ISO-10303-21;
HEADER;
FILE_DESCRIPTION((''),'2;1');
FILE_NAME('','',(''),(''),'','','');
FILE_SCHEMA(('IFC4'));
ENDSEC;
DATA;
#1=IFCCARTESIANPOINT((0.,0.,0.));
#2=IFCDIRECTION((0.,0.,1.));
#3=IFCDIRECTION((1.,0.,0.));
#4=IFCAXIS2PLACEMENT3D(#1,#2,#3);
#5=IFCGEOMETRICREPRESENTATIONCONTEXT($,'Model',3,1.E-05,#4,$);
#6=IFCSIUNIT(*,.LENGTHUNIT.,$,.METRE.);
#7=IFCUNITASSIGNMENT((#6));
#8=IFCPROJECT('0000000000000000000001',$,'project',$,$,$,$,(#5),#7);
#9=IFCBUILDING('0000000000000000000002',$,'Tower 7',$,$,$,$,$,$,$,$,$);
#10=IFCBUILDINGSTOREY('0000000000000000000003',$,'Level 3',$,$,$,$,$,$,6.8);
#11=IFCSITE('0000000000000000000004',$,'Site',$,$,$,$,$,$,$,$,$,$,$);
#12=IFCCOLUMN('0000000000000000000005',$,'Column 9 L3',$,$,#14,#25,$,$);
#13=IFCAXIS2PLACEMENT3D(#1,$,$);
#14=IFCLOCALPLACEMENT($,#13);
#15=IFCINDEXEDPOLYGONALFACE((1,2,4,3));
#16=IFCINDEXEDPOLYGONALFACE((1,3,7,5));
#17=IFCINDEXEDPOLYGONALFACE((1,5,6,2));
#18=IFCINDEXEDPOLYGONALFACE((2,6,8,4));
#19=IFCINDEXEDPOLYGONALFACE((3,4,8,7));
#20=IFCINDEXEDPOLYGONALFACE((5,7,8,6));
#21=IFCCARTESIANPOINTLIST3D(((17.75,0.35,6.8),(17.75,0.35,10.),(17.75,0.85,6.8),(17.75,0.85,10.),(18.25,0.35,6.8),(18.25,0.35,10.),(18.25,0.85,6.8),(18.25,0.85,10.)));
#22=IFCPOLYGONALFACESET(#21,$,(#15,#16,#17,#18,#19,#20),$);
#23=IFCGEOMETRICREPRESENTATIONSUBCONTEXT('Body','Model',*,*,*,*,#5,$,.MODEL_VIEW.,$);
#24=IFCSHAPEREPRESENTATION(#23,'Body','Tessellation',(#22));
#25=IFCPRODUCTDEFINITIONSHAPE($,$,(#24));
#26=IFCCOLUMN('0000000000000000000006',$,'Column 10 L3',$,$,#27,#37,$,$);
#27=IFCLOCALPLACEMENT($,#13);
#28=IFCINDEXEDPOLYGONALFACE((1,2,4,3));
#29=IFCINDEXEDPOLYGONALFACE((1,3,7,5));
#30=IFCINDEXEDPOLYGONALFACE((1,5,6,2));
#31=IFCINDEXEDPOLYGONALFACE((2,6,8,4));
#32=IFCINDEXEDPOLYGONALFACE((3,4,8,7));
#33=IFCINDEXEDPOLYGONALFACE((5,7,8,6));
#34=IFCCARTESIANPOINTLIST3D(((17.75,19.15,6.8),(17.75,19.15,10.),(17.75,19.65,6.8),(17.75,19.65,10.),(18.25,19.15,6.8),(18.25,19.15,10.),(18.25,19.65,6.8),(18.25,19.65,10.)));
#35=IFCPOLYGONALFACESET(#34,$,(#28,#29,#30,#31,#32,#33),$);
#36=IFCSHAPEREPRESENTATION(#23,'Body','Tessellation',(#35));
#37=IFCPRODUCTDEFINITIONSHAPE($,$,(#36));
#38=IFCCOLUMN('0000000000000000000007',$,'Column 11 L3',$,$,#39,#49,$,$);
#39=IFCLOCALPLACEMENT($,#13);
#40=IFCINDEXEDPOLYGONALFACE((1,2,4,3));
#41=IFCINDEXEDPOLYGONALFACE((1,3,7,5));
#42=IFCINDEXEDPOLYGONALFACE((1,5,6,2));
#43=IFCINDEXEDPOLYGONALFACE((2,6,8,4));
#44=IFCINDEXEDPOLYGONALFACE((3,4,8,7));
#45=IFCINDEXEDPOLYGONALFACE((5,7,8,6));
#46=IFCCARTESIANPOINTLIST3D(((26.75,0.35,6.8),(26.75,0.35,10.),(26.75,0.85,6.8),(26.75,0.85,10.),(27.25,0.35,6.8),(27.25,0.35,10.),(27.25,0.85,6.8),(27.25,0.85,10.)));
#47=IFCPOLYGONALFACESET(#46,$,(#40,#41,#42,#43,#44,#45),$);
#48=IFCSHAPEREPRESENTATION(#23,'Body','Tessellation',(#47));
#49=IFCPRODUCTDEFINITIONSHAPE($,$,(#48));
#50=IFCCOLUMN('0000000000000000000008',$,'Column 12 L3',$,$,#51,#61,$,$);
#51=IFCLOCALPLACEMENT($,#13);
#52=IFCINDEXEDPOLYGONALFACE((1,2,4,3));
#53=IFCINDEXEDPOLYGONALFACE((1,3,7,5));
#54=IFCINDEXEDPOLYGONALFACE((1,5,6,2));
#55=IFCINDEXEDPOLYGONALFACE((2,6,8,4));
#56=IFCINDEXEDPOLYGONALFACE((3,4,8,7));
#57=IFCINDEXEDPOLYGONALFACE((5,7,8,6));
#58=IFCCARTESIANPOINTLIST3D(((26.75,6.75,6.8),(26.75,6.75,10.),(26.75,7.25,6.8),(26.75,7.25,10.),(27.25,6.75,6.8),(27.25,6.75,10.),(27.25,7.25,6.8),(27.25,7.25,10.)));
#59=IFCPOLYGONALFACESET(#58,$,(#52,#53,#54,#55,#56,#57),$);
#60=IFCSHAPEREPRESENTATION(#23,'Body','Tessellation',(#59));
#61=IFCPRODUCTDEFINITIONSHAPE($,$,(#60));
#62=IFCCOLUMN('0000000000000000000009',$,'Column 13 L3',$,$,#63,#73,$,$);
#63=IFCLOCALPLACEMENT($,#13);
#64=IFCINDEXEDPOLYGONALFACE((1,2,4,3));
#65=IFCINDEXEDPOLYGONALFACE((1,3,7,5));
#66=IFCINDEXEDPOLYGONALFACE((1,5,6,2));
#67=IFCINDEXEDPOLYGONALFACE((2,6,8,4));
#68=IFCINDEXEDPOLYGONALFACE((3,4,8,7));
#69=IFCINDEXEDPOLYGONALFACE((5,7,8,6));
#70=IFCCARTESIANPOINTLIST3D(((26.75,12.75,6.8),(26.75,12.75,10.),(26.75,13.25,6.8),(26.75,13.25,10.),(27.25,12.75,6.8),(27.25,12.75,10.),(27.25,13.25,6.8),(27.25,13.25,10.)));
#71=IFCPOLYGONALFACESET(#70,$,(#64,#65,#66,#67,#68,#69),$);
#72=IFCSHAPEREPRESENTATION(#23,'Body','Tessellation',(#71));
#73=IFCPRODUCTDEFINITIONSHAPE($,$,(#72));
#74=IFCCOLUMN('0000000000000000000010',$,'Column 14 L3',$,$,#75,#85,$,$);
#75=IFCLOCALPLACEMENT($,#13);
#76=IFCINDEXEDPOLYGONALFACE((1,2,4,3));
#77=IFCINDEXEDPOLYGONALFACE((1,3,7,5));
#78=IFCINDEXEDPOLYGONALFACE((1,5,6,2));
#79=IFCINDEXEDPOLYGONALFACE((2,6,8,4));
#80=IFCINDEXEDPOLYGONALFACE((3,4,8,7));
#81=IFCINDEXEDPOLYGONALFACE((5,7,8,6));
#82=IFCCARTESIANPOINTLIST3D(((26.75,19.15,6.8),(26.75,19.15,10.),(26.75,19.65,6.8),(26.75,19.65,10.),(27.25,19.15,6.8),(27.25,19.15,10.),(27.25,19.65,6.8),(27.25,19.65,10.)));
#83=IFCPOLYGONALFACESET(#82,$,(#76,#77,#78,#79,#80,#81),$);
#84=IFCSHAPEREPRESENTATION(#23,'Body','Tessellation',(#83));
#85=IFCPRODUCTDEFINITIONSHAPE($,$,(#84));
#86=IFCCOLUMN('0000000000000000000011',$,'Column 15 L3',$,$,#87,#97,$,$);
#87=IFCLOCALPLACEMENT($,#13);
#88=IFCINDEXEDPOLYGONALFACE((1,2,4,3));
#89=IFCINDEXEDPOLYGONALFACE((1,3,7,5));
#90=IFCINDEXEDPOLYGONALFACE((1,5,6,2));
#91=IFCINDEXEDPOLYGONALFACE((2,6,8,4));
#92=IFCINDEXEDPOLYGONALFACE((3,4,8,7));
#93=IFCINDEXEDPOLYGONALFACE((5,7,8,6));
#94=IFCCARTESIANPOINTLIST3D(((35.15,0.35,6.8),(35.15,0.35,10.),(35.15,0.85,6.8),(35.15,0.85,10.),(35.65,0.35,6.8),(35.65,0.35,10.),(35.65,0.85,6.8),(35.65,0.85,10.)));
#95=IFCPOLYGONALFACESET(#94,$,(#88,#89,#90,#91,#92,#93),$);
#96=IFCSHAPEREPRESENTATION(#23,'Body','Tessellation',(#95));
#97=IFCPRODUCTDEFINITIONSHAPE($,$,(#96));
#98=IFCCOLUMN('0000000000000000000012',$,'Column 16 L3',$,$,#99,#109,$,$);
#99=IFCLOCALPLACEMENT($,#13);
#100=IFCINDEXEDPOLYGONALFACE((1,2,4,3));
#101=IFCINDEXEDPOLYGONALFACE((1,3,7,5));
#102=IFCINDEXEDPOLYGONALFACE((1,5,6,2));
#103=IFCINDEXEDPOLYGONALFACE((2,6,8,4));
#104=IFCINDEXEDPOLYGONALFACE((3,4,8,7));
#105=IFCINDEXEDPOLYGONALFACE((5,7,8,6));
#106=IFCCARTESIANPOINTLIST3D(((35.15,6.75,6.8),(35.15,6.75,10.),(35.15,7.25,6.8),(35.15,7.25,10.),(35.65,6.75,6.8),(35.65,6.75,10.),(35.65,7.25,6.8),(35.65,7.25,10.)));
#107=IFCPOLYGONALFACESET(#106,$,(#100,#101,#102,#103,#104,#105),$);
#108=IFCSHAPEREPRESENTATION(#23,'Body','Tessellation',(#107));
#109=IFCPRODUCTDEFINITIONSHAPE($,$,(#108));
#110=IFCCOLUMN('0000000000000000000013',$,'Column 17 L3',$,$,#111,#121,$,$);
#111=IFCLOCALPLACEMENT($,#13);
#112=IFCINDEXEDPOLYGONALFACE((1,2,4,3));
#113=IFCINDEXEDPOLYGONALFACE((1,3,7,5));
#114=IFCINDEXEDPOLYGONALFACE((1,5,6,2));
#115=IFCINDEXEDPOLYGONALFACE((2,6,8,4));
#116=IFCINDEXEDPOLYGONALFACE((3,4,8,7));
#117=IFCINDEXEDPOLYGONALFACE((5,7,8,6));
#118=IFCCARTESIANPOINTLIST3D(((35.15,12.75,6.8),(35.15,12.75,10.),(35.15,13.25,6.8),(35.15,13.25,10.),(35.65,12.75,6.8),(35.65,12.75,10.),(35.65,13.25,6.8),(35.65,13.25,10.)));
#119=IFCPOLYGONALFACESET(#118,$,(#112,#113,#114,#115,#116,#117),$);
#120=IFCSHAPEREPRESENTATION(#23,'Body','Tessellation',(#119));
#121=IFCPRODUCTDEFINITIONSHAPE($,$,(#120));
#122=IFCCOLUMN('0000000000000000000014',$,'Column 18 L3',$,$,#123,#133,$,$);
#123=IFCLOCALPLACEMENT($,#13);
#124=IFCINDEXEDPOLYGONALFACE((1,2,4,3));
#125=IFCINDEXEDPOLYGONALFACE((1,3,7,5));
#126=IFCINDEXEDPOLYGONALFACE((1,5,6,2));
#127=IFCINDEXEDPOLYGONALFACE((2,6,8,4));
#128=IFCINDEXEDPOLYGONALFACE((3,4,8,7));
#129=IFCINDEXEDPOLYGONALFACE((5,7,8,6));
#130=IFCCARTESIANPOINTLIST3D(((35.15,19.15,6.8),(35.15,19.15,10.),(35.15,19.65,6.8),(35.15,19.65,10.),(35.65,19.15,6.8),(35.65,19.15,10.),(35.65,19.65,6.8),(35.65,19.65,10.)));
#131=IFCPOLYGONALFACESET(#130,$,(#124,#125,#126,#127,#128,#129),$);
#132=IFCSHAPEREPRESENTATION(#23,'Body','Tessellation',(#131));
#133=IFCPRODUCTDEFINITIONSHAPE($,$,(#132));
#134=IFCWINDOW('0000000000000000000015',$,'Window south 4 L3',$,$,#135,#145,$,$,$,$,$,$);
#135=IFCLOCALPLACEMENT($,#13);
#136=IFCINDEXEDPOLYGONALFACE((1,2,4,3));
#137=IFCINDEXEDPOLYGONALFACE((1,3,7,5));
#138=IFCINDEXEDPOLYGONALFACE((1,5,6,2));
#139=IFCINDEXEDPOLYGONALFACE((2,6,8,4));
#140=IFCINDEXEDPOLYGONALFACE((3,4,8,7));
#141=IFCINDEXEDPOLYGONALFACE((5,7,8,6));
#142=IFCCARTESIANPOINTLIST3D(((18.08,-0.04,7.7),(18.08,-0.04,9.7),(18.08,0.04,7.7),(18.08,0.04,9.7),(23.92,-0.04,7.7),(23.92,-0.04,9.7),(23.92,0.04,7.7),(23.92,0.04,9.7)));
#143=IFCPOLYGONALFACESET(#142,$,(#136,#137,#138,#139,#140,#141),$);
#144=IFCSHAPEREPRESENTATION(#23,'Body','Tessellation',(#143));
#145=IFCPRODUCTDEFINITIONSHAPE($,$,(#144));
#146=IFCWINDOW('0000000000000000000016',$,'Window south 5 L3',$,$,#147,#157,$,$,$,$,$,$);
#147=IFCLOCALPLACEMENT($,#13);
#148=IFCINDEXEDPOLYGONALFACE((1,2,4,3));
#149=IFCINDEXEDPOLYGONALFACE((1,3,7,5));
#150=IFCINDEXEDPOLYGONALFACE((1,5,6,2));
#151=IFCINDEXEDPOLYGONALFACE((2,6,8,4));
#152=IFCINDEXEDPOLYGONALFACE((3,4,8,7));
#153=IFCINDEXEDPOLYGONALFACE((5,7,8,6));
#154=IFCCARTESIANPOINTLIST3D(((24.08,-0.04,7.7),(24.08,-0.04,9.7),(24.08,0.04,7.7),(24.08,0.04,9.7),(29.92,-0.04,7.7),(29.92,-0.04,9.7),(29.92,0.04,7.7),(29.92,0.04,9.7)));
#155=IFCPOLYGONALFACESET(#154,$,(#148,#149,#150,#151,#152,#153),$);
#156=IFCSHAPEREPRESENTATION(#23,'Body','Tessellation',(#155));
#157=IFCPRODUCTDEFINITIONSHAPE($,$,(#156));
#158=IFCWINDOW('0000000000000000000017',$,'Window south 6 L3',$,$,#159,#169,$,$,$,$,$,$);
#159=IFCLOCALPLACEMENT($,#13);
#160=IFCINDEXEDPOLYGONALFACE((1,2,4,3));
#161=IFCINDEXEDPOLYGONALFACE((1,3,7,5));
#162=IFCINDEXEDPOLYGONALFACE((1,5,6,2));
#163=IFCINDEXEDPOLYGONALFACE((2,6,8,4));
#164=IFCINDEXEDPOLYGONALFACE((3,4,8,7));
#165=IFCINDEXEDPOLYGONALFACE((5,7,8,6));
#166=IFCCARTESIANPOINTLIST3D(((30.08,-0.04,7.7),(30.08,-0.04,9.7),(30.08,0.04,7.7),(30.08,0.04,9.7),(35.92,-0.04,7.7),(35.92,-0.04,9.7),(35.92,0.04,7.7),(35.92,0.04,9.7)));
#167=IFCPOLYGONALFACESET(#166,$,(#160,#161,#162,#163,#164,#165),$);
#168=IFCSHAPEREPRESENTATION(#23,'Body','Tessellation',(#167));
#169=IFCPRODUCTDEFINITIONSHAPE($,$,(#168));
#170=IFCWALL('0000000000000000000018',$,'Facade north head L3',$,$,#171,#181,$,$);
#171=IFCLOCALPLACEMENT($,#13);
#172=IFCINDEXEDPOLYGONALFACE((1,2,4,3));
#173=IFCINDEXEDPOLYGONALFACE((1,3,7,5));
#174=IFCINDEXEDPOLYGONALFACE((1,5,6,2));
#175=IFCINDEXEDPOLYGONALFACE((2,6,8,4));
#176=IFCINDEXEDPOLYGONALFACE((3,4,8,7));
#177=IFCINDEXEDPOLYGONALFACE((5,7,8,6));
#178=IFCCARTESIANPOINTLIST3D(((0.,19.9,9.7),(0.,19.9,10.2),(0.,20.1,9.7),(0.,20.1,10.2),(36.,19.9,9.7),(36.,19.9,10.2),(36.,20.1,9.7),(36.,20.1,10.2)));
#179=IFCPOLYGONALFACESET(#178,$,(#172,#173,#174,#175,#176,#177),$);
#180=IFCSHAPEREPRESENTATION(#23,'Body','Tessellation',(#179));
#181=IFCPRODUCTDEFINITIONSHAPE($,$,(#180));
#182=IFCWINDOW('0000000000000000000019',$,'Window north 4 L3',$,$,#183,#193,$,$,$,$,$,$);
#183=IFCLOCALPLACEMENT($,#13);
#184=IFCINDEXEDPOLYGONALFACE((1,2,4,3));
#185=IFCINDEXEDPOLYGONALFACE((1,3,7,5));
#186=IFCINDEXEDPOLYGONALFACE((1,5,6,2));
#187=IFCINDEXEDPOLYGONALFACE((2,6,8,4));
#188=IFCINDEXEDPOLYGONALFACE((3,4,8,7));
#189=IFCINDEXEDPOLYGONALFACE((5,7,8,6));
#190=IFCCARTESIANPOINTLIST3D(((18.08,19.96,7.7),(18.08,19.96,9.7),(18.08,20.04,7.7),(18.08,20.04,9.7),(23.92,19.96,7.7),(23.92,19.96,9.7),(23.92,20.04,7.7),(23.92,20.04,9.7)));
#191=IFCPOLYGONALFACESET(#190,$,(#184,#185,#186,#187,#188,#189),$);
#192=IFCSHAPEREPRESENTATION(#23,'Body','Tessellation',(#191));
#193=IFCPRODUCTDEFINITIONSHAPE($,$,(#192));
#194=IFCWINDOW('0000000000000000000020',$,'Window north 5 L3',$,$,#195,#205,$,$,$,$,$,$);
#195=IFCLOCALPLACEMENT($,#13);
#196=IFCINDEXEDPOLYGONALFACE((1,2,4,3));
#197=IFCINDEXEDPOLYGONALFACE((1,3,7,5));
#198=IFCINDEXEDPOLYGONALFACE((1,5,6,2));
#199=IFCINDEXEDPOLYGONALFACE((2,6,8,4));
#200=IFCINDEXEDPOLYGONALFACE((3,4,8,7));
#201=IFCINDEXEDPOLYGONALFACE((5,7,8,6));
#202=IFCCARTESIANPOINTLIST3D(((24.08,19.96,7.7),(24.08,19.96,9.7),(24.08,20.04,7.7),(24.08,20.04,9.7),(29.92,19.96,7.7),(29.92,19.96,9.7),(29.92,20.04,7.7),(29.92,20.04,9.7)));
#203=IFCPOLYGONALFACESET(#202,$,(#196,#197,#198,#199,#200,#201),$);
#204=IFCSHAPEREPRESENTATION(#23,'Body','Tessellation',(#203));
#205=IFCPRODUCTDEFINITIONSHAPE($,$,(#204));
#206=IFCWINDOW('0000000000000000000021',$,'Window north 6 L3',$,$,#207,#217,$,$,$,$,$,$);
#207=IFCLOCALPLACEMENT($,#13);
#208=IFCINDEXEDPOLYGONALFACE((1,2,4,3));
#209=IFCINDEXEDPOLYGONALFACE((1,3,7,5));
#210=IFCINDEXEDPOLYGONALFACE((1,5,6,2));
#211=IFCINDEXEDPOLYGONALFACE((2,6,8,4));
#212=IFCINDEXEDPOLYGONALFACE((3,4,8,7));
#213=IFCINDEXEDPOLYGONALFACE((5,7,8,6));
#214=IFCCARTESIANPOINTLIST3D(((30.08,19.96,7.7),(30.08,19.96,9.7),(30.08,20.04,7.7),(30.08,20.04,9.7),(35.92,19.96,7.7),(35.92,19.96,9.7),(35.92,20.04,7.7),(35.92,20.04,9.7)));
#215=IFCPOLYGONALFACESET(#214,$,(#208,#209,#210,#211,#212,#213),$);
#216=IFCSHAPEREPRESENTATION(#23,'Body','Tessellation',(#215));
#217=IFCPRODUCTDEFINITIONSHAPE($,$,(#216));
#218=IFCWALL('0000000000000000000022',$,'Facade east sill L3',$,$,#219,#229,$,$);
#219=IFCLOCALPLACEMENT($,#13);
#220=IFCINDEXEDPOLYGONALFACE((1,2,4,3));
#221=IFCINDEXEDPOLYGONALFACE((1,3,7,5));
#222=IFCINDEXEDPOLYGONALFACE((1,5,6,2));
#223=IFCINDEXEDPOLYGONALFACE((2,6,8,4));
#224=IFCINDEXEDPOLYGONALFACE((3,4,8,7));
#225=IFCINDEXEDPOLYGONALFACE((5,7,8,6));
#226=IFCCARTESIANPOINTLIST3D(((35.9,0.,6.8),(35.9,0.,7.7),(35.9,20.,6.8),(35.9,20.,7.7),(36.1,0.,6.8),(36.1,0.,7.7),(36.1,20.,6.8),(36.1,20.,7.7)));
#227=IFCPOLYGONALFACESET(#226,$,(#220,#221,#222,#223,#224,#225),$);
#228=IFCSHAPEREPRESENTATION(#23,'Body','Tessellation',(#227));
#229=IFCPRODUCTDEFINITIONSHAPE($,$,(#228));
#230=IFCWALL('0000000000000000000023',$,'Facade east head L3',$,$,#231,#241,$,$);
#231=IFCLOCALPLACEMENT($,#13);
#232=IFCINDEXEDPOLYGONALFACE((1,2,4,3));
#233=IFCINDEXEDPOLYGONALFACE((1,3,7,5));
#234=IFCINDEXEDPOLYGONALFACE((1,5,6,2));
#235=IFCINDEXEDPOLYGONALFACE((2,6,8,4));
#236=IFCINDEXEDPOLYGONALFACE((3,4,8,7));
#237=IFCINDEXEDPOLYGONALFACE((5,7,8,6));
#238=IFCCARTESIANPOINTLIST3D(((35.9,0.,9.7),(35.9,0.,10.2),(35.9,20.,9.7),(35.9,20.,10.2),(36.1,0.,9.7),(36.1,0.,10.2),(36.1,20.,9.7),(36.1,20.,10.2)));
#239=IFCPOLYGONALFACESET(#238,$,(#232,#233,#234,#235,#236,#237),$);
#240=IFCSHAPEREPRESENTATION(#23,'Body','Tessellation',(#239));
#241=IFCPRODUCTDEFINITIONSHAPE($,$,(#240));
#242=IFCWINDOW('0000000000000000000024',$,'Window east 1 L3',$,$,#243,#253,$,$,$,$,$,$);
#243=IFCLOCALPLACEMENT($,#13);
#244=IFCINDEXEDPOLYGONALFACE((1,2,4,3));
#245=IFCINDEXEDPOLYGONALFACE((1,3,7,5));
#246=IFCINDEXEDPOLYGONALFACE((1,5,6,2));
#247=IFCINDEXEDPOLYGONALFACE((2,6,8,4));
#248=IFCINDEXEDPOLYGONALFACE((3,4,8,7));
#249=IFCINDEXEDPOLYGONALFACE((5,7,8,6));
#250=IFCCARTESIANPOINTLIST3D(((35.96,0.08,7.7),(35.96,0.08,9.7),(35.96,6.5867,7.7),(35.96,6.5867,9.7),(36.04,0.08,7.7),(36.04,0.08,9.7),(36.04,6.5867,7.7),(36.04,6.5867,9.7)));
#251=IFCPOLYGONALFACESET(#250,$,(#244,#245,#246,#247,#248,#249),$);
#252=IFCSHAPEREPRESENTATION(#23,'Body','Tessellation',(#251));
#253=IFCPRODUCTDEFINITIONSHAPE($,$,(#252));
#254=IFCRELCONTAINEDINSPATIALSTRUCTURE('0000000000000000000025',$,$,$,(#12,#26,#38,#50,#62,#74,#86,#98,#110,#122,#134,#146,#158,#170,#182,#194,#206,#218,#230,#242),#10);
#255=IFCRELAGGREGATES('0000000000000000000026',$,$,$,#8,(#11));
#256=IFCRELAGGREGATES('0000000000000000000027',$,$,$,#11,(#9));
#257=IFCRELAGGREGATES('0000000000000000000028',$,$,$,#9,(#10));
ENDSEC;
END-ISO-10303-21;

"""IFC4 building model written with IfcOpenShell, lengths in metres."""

from ifc_helpers import new_model, si_unit, frame, origin, origin_with_axes, origin_2d, place, context, subcontext, project, spatial, rectangle, extrude, element, save


model = new_model("IFC4")

# Units and contexts
model_context = context("Model", 3, precision=1e-05, world=origin_with_axes())
body_context = subcontext(model_context, "Body", "Model", "MODEL_VIEW")
ifc_project = project(units=[si_unit("LENGTHUNIT", "METRE")], contexts=[model_context])

# Site, building, storey
site = spatial("IfcSite", under=ifc_project, Name="Site")
building = spatial("IfcBuilding", under=site, Name="Tower 7")
storey = spatial("IfcBuildingStorey", under=building, Name="Level 3", Elevation=6.8)

# Columns
for number, where, z_axis, x_axis, name in (
    (1, (18.0, 0.6, 6.8), (0.0, 0.0, 1.0), (1.0, 0.0, 0.0), "Column 9 L3"),
    (2, (18.0, 19.4, 6.8), (0.0, 0.0, 1.0), (1.0, 0.0, 0.0), "Column 10 L3"),
    (3, (27.0, 0.6, 6.8), (0.0, 0.0, 1.0), (1.0, 0.0, 0.0), "Column 11 L3"),
    (4, (27.0, 7.0, 6.8), (0.0, 0.0, 1.0), (1.0, 0.0, 0.0), "Column 12 L3"),
    (5, (27.0, 13.0, 6.8), (0.0, 0.0, 1.0), (1.0, 0.0, 0.0), "Column 13 L3"),
    (6, (27.0, 19.4, 6.8), (0.0, 0.0, 1.0), (1.0, 0.0, 0.0), "Column 14 L3"),
    (7, (35.4, 0.6, 6.8), (0.0, 0.0, 1.0), (1.0, 0.0, 0.0), "Column 15 L3"),
    (8, (35.4, 7.0, 6.8), (0.0, 0.0, 1.0), (1.0, 0.0, 0.0), "Column 16 L3"),
    (9, (35.4, 13.0, 6.8), (0.0, 0.0, 1.0), (1.0, 0.0, 0.0), "Column 17 L3"),
    (10, (35.4, 19.4, 6.8), (0.0, 0.0, 1.0), (1.0, 0.0, 0.0), "Column 18 L3"),
):
    element("IfcColumn", number, at=place(None, frame(where, z_axis=z_axis, x_axis=x_axis)), inside=storey, Name=name, context=body_context, shape_type="SweptSolid", body=[
        extrude(rectangle(XDim=0.5, YDim=0.5, at=origin_2d()), origin(), (0.0, 0.0, 1.0), 3.2),
    ])

# Windows
for number, where, z_axis, x_axis, name in (
    (11, (21.0, 0.0, 7.7), (0.0, 0.0, 1.0), (1.0, 0.0, 0.0), "Window south 4 L3"),
    (12, (27.0, 0.0, 7.7), (0.0, 0.0, 1.0), (1.0, 0.0, 0.0), "Window south 5 L3"),
    (13, (33.0, 0.0, 7.7), (0.0, 0.0, 1.0), (1.0, 0.0, 0.0), "Window south 6 L3"),
):
    element("IfcWindow", number, at=place(None, frame(where, z_axis=z_axis, x_axis=x_axis)), inside=storey, Name=name, context=body_context, shape_type="SweptSolid", body=[
        extrude(rectangle(XDim=5.84, YDim=0.08, at=origin_2d()), origin(), (0.0, 0.0, 1.0), 2.0),
    ])

# Wall
wall_1_placement = place(None, frame((18.0, 20.0, 9.7), z_axis=(0.0, 0.0, 1.0), x_axis=(1.0, 0.0, 0.0)))
element("IfcWall", 14, at=wall_1_placement, inside=storey, Name="Facade north head L3", context=body_context, shape_type="SweptSolid", body=[
    extrude(rectangle(XDim=36.0, YDim=0.2, at=origin_2d()), origin(), (0.0, 0.0, 1.0), 0.5),
])

# Windows
for number, where, z_axis, x_axis, name in (
    (15, (21.0, 20.0, 7.7), (0.0, 0.0, 1.0), (1.0, 0.0, 0.0), "Window north 4 L3"),
    (16, (27.0, 20.0, 7.7), (0.0, 0.0, 1.0), (1.0, 0.0, 0.0), "Window north 5 L3"),
    (17, (33.0, 20.0, 7.7), (0.0, 0.0, 1.0), (1.0, 0.0, 0.0), "Window north 6 L3"),
):
    element("IfcWindow", number, at=place(None, frame(where, z_axis=z_axis, x_axis=x_axis)), inside=storey, Name=name, context=body_context, shape_type="SweptSolid", body=[
        extrude(rectangle(XDim=5.84, YDim=0.08, at=origin_2d()), origin(), (0.0, 0.0, 1.0), 2.0),
    ])

# Walls
wall_2_placement = place(None, frame((36.0, 10.0, 6.8), z_axis=(0.0, 0.0, 1.0), x_axis=(1.0, 0.0, 0.0)))
element("IfcWall", 18, at=wall_2_placement, inside=storey, Name="Facade east sill L3", context=body_context, shape_type="SweptSolid", body=[
    extrude(rectangle(XDim=0.2, YDim=20.0, at=origin_2d()), origin(), (0.0, 0.0, 1.0), 0.9),
])
wall_3_placement = place(None, frame((36.0, 10.0, 9.7), z_axis=(0.0, 0.0, 1.0), x_axis=(1.0, 0.0, 0.0)))
element("IfcWall", 19, at=wall_3_placement, inside=storey, Name="Facade east head L3", context=body_context, shape_type="SweptSolid", body=[
    extrude(rectangle(XDim=0.2, YDim=20.0, at=origin_2d()), origin(), (0.0, 0.0, 1.0), 0.5),
])

# Window
for number, where, z_axis, x_axis, name in (
    (20, (36.0, 3.3333, 7.7), (0.0, 0.0, 1.0), (1.0, 0.0, 0.0), "Window east 1 L3"),
):
    element("IfcWindow", number, at=place(None, frame(where, z_axis=z_axis, x_axis=x_axis)), inside=storey, Name=name, context=body_context, shape_type="SweptSolid", body=[
        extrude(rectangle(XDim=0.08, YDim=6.5067, at=origin_2d()), origin(), (0.0, 0.0, 1.0), 2.0),
    ])

save(model, "model.ifc")
